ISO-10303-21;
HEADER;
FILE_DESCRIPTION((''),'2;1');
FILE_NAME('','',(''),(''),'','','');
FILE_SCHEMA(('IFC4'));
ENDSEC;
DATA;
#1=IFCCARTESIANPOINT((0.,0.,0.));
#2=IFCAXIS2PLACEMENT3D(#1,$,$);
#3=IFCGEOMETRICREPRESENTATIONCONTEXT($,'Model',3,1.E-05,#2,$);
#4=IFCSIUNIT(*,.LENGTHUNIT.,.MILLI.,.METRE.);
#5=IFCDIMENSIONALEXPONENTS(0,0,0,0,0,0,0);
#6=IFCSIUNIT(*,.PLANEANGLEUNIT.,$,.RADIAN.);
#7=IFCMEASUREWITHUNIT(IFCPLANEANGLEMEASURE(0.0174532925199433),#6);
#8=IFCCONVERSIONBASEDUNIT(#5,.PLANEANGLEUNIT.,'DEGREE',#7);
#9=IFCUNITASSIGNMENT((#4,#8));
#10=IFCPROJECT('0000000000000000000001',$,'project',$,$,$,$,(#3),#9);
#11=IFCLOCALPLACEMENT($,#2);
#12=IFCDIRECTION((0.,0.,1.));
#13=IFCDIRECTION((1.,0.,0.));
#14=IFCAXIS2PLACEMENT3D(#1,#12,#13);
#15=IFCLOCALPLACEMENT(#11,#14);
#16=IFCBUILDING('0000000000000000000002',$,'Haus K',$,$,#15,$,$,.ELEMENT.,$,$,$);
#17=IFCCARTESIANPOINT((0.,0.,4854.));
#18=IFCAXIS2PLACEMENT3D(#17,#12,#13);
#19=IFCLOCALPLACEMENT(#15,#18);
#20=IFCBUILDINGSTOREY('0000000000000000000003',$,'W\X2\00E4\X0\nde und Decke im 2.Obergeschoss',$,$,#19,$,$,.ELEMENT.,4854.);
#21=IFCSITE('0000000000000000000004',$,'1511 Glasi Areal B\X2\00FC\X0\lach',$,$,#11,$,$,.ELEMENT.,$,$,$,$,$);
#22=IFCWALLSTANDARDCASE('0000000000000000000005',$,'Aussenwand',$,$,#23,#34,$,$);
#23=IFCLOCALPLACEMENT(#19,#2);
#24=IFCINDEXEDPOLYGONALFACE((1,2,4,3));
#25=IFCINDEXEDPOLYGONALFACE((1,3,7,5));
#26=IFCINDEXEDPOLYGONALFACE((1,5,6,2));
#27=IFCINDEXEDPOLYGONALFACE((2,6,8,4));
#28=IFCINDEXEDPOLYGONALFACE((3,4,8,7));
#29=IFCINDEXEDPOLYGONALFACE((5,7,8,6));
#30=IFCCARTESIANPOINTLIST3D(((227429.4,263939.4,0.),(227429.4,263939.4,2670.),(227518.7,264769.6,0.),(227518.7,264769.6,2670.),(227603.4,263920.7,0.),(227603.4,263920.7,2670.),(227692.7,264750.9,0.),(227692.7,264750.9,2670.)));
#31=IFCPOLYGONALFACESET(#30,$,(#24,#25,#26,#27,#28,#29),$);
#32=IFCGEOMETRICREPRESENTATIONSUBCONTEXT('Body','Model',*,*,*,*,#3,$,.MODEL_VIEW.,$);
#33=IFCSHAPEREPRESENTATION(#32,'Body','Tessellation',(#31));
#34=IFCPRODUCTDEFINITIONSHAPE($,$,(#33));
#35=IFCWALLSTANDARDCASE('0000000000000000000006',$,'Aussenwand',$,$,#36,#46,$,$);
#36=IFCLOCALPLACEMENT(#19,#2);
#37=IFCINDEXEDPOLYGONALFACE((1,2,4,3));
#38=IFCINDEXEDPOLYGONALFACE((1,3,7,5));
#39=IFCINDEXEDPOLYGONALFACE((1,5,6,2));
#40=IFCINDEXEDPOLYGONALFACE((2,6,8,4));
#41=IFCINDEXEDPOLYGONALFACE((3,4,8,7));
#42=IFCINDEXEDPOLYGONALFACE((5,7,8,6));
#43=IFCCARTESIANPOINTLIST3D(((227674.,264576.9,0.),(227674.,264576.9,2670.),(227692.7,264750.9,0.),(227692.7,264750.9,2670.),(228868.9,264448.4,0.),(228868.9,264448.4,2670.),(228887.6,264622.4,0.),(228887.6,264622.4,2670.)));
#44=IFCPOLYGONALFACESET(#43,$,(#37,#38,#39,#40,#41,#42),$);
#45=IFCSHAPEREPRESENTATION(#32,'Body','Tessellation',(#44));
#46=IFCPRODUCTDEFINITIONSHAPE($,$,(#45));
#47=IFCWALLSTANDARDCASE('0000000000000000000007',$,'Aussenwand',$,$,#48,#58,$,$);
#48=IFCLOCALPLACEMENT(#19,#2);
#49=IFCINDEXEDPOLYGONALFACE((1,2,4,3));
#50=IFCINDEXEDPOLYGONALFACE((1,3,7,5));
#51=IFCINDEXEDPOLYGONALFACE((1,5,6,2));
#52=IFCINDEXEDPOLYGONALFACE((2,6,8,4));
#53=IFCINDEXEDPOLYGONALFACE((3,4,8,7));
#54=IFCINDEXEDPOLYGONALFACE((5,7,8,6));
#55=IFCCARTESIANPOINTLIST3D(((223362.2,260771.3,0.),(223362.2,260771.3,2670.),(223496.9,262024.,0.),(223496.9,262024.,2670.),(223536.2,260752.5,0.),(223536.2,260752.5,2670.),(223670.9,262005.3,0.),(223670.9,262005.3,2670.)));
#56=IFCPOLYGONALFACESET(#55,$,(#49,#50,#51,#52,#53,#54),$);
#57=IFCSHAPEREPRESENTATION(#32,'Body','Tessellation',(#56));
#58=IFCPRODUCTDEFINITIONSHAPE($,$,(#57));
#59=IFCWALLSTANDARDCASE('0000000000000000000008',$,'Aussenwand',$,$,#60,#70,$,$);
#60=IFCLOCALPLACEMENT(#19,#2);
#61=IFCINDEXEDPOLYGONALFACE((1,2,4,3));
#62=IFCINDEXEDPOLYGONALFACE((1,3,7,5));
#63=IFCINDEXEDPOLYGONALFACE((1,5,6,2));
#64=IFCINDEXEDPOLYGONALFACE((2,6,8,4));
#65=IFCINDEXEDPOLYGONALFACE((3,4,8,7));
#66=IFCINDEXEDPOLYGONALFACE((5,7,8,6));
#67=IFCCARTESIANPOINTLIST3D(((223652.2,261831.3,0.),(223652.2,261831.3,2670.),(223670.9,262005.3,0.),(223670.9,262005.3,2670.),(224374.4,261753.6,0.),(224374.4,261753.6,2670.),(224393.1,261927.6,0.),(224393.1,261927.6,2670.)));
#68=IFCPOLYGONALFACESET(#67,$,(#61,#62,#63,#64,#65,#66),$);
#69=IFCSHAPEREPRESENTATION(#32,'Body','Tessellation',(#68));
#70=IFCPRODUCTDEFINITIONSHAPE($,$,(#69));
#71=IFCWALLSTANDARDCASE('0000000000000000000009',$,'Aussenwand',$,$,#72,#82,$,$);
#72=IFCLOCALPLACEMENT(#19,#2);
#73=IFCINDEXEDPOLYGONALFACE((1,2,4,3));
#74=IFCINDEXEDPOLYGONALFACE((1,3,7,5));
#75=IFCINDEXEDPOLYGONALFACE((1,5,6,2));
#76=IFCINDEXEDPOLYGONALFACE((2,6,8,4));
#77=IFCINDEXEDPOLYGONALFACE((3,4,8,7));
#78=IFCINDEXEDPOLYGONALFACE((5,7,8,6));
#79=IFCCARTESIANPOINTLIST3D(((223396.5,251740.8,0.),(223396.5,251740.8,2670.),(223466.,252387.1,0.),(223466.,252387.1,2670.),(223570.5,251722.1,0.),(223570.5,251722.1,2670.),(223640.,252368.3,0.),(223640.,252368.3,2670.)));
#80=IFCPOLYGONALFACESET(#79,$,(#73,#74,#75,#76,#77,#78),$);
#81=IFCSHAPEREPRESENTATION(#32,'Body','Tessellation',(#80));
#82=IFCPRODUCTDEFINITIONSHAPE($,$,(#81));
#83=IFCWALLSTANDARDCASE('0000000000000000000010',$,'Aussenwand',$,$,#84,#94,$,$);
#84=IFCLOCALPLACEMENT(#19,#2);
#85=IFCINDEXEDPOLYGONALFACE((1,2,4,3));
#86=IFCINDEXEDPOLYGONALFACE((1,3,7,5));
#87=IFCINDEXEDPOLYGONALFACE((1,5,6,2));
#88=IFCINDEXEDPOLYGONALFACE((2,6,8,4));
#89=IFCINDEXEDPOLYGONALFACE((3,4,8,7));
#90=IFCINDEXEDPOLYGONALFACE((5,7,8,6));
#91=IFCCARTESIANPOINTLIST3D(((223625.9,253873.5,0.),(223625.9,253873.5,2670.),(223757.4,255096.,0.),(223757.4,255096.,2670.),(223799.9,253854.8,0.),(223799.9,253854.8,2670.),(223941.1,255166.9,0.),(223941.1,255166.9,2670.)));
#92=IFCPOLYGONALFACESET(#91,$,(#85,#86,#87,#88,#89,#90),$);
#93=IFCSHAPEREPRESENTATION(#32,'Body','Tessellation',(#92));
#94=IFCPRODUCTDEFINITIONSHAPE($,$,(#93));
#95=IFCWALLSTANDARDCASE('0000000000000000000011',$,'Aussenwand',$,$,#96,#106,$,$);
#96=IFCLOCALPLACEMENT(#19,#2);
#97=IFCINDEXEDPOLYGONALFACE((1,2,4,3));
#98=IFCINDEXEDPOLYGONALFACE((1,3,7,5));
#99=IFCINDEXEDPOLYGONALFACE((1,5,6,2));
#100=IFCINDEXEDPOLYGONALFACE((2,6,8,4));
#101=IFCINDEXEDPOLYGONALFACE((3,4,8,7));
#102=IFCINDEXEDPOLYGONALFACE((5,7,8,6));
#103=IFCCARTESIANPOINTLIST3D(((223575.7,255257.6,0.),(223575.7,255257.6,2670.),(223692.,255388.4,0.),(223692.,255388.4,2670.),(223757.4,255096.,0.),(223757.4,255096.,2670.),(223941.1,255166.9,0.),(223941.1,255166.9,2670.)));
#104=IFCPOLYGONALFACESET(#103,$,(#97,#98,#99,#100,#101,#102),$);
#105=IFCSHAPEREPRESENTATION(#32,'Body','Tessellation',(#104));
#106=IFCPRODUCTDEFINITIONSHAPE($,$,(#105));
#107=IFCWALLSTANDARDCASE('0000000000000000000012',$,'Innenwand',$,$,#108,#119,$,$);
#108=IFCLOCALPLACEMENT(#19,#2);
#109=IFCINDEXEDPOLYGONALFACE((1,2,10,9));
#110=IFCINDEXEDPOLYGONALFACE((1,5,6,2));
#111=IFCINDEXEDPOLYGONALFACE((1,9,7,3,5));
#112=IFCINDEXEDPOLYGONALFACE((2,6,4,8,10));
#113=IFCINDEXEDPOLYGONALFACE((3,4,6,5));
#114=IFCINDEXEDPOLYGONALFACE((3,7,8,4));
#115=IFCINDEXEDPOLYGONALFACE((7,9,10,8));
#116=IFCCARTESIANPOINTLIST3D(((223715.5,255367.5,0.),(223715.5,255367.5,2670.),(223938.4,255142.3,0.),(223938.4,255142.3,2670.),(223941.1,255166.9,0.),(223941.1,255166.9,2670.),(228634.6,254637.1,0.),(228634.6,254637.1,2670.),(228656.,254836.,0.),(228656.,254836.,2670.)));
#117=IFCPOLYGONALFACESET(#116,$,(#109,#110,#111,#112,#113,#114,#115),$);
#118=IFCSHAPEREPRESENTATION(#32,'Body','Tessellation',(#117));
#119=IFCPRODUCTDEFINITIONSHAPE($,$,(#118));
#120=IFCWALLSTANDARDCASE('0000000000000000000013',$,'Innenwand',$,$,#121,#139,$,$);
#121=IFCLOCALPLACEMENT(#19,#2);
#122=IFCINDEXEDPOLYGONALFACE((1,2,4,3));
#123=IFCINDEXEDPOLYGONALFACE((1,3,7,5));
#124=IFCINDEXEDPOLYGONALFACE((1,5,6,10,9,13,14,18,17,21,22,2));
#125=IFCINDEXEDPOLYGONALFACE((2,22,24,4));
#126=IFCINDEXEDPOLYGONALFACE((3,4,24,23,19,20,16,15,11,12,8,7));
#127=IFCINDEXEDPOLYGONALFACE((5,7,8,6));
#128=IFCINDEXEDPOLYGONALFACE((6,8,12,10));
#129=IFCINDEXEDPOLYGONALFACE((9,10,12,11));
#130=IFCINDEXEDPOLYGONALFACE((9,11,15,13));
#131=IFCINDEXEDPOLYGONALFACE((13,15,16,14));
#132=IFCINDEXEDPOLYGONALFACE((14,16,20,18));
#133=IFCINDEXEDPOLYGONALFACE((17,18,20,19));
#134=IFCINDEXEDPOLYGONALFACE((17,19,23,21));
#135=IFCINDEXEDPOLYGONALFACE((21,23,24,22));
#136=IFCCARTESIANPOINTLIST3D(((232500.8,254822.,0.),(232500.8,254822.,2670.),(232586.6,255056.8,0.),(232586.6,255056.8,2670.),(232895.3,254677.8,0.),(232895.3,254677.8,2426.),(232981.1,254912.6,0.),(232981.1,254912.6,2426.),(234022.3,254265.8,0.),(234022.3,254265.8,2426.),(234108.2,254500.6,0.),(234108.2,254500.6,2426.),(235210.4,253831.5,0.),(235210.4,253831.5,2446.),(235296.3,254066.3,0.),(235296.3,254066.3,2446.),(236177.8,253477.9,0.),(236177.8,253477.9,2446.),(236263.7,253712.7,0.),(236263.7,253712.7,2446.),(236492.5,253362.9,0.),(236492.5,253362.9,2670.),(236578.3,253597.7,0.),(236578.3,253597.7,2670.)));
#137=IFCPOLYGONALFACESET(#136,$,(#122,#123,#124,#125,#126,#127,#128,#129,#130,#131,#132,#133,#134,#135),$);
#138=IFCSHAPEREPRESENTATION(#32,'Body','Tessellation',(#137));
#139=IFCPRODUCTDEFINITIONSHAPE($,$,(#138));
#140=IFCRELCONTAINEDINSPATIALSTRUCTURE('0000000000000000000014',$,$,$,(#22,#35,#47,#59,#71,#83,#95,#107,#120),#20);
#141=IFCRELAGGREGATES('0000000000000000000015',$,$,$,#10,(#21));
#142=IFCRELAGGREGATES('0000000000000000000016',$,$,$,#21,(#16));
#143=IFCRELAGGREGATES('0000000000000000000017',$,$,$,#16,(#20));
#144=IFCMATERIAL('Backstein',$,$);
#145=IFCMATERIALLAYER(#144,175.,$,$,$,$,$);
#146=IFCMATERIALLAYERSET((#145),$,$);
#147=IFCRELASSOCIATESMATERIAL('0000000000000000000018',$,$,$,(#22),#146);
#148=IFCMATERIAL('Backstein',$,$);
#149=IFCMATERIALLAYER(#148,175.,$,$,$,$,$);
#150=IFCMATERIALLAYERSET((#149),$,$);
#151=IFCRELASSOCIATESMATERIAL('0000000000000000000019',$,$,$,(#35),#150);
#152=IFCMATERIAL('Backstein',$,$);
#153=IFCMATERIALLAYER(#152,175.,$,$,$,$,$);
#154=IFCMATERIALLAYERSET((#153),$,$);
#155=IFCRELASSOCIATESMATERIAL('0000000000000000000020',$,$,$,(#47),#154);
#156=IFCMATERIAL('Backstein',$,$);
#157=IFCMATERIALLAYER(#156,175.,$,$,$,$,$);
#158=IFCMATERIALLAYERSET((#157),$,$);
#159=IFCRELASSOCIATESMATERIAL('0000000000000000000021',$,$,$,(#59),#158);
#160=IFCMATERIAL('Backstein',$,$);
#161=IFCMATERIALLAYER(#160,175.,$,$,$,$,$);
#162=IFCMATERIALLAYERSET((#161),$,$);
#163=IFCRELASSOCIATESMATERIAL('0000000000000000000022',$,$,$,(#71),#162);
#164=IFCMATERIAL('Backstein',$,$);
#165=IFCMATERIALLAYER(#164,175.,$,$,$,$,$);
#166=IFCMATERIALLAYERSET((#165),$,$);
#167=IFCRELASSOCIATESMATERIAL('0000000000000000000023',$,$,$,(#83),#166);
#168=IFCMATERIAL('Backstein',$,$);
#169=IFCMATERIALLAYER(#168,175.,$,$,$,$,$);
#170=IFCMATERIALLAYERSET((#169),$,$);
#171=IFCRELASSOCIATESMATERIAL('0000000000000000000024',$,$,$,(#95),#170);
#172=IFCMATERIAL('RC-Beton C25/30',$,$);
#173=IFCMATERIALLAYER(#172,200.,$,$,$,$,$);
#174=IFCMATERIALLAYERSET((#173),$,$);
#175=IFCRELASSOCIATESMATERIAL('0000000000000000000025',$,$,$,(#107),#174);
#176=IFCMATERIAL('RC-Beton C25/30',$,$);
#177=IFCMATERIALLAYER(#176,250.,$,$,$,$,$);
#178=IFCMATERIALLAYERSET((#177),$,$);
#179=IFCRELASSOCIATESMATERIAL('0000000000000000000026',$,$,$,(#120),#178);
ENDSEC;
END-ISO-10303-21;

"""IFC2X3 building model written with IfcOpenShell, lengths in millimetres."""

from ifc_helpers import new_model, entity, si_unit, converted_unit, frame, frame_2d, origin, origin_with_axes, place, context, subcontext, project, spatial, polyline, rectangle, outline, extrude, material, layer, layer_set, layer_usage, element, save


model = new_model("IFC2X3")

# Units and contexts
model_context = context("Model", 3, precision=1e-05, world=origin())
body_context = subcontext(model_context, "Body", "Model", "MODEL_VIEW")
ifc_project = project(units=[si_unit("LENGTHUNIT", "METRE", prefix="MILLI"), converted_unit("PLANEANGLEUNIT", "DEGREE", entity("IfcPlaneAngleMeasure", 0.0174532925199433), si_unit("PLANEANGLEUNIT", "RADIAN"), dimensions=[0, 0, 0, 0, 0, 0, 0])], contexts=[model_context])

# Site, building, storey
site_placement = place(None, origin())
site = spatial("IfcSite", under=ifc_project, at=site_placement, Name="1511 Glasi Areal Bülach", CompositionType="ELEMENT")
building_placement = place(site_placement, origin_with_axes())
building = spatial("IfcBuilding", under=site, at=building_placement, Name="Haus K", CompositionType="ELEMENT")
storey_placement = place(building_placement, frame((0.0, 0.0, 4854.0), z_axis=(0.0, 0.0, 1.0), x_axis=(1.0, 0.0, 0.0)))
storey = spatial("IfcBuildingStorey", under=building, at=storey_placement, Name="Wände und Decke im 2.Obergeschoss", CompositionType="ELEMENT", Elevation=4854.0)

# Walls
ifc_material_1 = material(Name="Backstein")
ifc_layer_1 = layer(ifc_material_1, 175.0)
ifc_layer_set_1 = layer_set([ifc_layer_1])
ifc_layer_usage_1 = layer_usage(ifc_layer_set_1, "AXIS2", "POSITIVE", 0.0)
wall_1_placement = place(storey_placement, frame((227518.7, 264769.6, 0.0), z_axis=(0.0, 0.0, 1.0), x_axis=(-0.106958, -0.994264, 0.0)))
element("IfcWallStandardCase", 1, at=wall_1_placement, inside=storey, material=ifc_layer_usage_1, Name="Aussenwand", context=body_context, shape_type="SweptSolid", body=[
    extrude(rectangle(XDim=835.0, YDim=175.0, at=frame_2d((417.5, 87.5), x_axis=(1.0, 0.0))), origin_with_axes(), (0.0, 0.0, 1.0), 2670.0),
])
ifc_material_2 = material(Name="Backstein")
ifc_layer_2 = layer(ifc_material_2, 175.0)
ifc_layer_set_2 = layer_set([ifc_layer_2])
ifc_layer_usage_2 = layer_usage(ifc_layer_set_2, "AXIS2", "POSITIVE", 0.0)
wall_2_placement = place(storey_placement, frame((228887.6, 264622.4, 0.0), z_axis=(0.0, 0.0, 1.0), x_axis=(-0.994264, 0.106958, 0.0)))
element("IfcWallStandardCase", 2, at=wall_2_placement, inside=storey, material=ifc_layer_usage_2, Name="Aussenwand", context=body_context, shape_type="SweptSolid", body=[
    extrude(rectangle(XDim=1201.8, YDim=175.0, at=frame_2d((600.9, 87.5), x_axis=(1.0, 0.0))), origin_with_axes(), (0.0, 0.0, 1.0), 2670.0),
])
ifc_material_3 = material(Name="Backstein")
ifc_layer_3 = layer(ifc_material_3, 175.0)
ifc_layer_set_3 = layer_set([ifc_layer_3])
ifc_layer_usage_3 = layer_usage(ifc_layer_set_3, "AXIS2", "POSITIVE", 0.0)
wall_3_placement = place(storey_placement, frame((223496.9, 262024.0, 0.0), z_axis=(0.0, 0.0, 1.0), x_axis=(-0.106958, -0.994264, 0.0)))
element("IfcWallStandardCase", 3, at=wall_3_placement, inside=storey, material=ifc_layer_usage_3, Name="Aussenwand", context=body_context, shape_type="SweptSolid", body=[
    extrude(rectangle(XDim=1260.0, YDim=175.0, at=frame_2d((630.0, 87.5), x_axis=(1.0, 0.0))), origin_with_axes(), (0.0, 0.0, 1.0), 2670.0),
])
ifc_material_4 = material(Name="Backstein")
ifc_layer_4 = layer(ifc_material_4, 175.0)
ifc_layer_set_4 = layer_set([ifc_layer_4])
ifc_layer_usage_4 = layer_usage(ifc_layer_set_4, "AXIS2", "POSITIVE", 0.0)
wall_4_placement = place(storey_placement, frame((224393.1, 261927.6, 0.0), z_axis=(0.0, 0.0, 1.0), x_axis=(-0.994264, 0.106958, 0.0)))
element("IfcWallStandardCase", 4, at=wall_4_placement, inside=storey, material=ifc_layer_usage_4, Name="Aussenwand", context=body_context, shape_type="SweptSolid", body=[
    extrude(rectangle(XDim=726.3, YDim=175.0, at=frame_2d((363.1, 87.5), x_axis=(1.0, 0.0))), origin_with_axes(), (0.0, 0.0, 1.0), 2670.0),
])
ifc_material_5 = material(Name="Backstein")
ifc_layer_5 = layer(ifc_material_5, 175.0)
ifc_layer_set_5 = layer_set([ifc_layer_5])
ifc_layer_usage_5 = layer_usage(ifc_layer_set_5, "AXIS2", "POSITIVE", 0.0)
wall_5_placement = place(storey_placement, frame((223466.0, 252387.1, 0.0), z_axis=(0.0, 0.0, 1.0), x_axis=(-0.106958, -0.994264, 0.0)))
element("IfcWallStandardCase", 5, at=wall_5_placement, inside=storey, material=ifc_layer_usage_5, Name="Aussenwand", context=body_context, shape_type="SweptSolid", body=[
    extrude(outline(polyline([(0.0, 0.0), (650.0, 0.0), (650.0, 175.0), (0.0, 175.0), (0.0, 0.0)])), origin_with_axes(), (0.0, 0.0, 1.0), 2670.0),
])
ifc_material_6 = material(Name="Backstein")
ifc_layer_6 = layer(ifc_material_6, 175.0)
ifc_layer_set_6 = layer_set([ifc_layer_6])
ifc_layer_usage_6 = layer_usage(ifc_layer_set_6, "AXIS2", "POSITIVE", 0.0)
wall_6_placement = place(storey_placement, frame((223757.4, 255096.0, 0.0), z_axis=(0.0, 0.0, 1.0), x_axis=(-0.106958, -0.994264, 0.0)))
element("IfcWallStandardCase", 6, at=wall_6_placement, inside=storey, material=ifc_layer_usage_6, Name="Aussenwand", context=body_context, shape_type="SweptSolid", body=[
    extrude(outline(polyline([(0.0, 0.0), (1229.6, 0.0), (1229.6, 175.0), (-90.1, 175.0), (0.0, 0.0)])), origin_with_axes(), (0.0, 0.0, 1.0), 2670.0),
])
ifc_material_7 = material(Name="Backstein")
ifc_layer_7 = layer(ifc_material_7, 175.0)
ifc_layer_set_7 = layer_set([ifc_layer_7])
ifc_layer_usage_7 = layer_usage(ifc_layer_set_7, "AXIS2", "POSITIVE", 0.0)
wall_7_placement = place(storey_placement, frame((223575.7, 255257.6, 0.0), z_axis=(0.0, 0.0, 1.0), x_axis=(0.747334, -0.664448, 0.0)))
element("IfcWallStandardCase", 7, at=wall_7_placement, inside=storey, material=ifc_layer_usage_7, Name="Aussenwand", context=body_context, shape_type="SweptSolid", body=[
    extrude(outline(polyline([(0.0, 0.0), (243.1, 0.0), (333.3, 175.0), (0.0, 175.0), (0.0, 0.0)])), origin_with_axes(), (0.0, 0.0, 1.0), 2670.0),
])
ifc_material_8 = material(Name="RC-Beton C25/30")
ifc_layer_8 = layer(ifc_material_8, 200.0)
ifc_layer_set_8 = layer_set([ifc_layer_8])
ifc_layer_usage_8 = layer_usage(ifc_layer_set_8, "AXIS2", "POSITIVE", 0.0)
wall_8_placement = place(storey_placement, frame((223938.4, 255142.3, 0.0), z_axis=(0.0, 0.0, 1.0), x_axis=(0.994264, -0.106958, 0.0)))
element("IfcWallStandardCase", 8, at=wall_8_placement, inside=storey, material=ifc_layer_usage_8, Name="Innenwand", context=body_context, shape_type="SweptSolid", body=[
    extrude(outline(polyline([(0.0, 0.0), (4723.3, 0.0), (4723.3, 200.0), (-245.7, 200.0), (0.0, 24.8), (0.0, 0.0)])), origin_with_axes(), (0.0, 0.0, 1.0), 2670.0),
])

# Wall, openings
ifc_material_9 = material(Name="RC-Beton C25/30")
ifc_layer_9 = layer(ifc_material_9, 250.0)
ifc_layer_set_9 = layer_set([ifc_layer_9])
ifc_layer_usage_9 = layer_usage(ifc_layer_set_9, "AXIS2", "POSITIVE", 0.0)
wall_9_placement = place(storey_placement, frame((232500.8, 254822.0, 0.0), z_axis=(0.0, 0.0, 1.0), x_axis=(0.939214, -0.343332, 0.0)))
wall_9 = element("IfcWallStandardCase", 9, at=wall_9_placement, inside=storey, material=ifc_layer_usage_9, Name="Innenwand", context=body_context, shape_type="SweptSolid", body=[
    extrude(rectangle(XDim=4250.0, YDim=250.0, at=frame_2d((2125.0, 125.0), x_axis=(1.0, 0.0))), origin_with_axes(), (0.0, 0.0, 1.0), 2670.0),
])
opening_1_placement = place(wall_9_placement, frame((2885.0, 0.0, 0.0), z_axis=(0.0, 1.0, 0.0), x_axis=(0.0, 0.0, 1.0)))
element("IfcOpeningElement", 10, at=opening_1_placement, cuts=wall_9, ObjectType="Opening", context=body_context, shape_type="SweptSolid", body=[
    extrude(rectangle(XDim=2446.0, YDim=1030.0, at=frame_2d((1223.0, 515.0), x_axis=(1.0, 0.0))), origin_with_axes(), (0.0, 0.0, 1.0), 250.0),
])
opening_2_placement = place(wall_9_placement, frame((420.0, 0.0, 0.0), z_axis=(0.0, 1.0, 0.0), x_axis=(0.0, 0.0, 1.0)))
element("IfcOpeningElement", 11, at=opening_2_placement, cuts=wall_9, ObjectType="Opening", context=body_context, shape_type="SweptSolid", body=[
    extrude(rectangle(XDim=2426.0, YDim=1200.0, at=frame_2d((1213.0, 600.0), x_axis=(1.0, 0.0))), origin_with_axes(), (0.0, 0.0, 1.0), 250.0),
])

save(model, "model.ifc")
